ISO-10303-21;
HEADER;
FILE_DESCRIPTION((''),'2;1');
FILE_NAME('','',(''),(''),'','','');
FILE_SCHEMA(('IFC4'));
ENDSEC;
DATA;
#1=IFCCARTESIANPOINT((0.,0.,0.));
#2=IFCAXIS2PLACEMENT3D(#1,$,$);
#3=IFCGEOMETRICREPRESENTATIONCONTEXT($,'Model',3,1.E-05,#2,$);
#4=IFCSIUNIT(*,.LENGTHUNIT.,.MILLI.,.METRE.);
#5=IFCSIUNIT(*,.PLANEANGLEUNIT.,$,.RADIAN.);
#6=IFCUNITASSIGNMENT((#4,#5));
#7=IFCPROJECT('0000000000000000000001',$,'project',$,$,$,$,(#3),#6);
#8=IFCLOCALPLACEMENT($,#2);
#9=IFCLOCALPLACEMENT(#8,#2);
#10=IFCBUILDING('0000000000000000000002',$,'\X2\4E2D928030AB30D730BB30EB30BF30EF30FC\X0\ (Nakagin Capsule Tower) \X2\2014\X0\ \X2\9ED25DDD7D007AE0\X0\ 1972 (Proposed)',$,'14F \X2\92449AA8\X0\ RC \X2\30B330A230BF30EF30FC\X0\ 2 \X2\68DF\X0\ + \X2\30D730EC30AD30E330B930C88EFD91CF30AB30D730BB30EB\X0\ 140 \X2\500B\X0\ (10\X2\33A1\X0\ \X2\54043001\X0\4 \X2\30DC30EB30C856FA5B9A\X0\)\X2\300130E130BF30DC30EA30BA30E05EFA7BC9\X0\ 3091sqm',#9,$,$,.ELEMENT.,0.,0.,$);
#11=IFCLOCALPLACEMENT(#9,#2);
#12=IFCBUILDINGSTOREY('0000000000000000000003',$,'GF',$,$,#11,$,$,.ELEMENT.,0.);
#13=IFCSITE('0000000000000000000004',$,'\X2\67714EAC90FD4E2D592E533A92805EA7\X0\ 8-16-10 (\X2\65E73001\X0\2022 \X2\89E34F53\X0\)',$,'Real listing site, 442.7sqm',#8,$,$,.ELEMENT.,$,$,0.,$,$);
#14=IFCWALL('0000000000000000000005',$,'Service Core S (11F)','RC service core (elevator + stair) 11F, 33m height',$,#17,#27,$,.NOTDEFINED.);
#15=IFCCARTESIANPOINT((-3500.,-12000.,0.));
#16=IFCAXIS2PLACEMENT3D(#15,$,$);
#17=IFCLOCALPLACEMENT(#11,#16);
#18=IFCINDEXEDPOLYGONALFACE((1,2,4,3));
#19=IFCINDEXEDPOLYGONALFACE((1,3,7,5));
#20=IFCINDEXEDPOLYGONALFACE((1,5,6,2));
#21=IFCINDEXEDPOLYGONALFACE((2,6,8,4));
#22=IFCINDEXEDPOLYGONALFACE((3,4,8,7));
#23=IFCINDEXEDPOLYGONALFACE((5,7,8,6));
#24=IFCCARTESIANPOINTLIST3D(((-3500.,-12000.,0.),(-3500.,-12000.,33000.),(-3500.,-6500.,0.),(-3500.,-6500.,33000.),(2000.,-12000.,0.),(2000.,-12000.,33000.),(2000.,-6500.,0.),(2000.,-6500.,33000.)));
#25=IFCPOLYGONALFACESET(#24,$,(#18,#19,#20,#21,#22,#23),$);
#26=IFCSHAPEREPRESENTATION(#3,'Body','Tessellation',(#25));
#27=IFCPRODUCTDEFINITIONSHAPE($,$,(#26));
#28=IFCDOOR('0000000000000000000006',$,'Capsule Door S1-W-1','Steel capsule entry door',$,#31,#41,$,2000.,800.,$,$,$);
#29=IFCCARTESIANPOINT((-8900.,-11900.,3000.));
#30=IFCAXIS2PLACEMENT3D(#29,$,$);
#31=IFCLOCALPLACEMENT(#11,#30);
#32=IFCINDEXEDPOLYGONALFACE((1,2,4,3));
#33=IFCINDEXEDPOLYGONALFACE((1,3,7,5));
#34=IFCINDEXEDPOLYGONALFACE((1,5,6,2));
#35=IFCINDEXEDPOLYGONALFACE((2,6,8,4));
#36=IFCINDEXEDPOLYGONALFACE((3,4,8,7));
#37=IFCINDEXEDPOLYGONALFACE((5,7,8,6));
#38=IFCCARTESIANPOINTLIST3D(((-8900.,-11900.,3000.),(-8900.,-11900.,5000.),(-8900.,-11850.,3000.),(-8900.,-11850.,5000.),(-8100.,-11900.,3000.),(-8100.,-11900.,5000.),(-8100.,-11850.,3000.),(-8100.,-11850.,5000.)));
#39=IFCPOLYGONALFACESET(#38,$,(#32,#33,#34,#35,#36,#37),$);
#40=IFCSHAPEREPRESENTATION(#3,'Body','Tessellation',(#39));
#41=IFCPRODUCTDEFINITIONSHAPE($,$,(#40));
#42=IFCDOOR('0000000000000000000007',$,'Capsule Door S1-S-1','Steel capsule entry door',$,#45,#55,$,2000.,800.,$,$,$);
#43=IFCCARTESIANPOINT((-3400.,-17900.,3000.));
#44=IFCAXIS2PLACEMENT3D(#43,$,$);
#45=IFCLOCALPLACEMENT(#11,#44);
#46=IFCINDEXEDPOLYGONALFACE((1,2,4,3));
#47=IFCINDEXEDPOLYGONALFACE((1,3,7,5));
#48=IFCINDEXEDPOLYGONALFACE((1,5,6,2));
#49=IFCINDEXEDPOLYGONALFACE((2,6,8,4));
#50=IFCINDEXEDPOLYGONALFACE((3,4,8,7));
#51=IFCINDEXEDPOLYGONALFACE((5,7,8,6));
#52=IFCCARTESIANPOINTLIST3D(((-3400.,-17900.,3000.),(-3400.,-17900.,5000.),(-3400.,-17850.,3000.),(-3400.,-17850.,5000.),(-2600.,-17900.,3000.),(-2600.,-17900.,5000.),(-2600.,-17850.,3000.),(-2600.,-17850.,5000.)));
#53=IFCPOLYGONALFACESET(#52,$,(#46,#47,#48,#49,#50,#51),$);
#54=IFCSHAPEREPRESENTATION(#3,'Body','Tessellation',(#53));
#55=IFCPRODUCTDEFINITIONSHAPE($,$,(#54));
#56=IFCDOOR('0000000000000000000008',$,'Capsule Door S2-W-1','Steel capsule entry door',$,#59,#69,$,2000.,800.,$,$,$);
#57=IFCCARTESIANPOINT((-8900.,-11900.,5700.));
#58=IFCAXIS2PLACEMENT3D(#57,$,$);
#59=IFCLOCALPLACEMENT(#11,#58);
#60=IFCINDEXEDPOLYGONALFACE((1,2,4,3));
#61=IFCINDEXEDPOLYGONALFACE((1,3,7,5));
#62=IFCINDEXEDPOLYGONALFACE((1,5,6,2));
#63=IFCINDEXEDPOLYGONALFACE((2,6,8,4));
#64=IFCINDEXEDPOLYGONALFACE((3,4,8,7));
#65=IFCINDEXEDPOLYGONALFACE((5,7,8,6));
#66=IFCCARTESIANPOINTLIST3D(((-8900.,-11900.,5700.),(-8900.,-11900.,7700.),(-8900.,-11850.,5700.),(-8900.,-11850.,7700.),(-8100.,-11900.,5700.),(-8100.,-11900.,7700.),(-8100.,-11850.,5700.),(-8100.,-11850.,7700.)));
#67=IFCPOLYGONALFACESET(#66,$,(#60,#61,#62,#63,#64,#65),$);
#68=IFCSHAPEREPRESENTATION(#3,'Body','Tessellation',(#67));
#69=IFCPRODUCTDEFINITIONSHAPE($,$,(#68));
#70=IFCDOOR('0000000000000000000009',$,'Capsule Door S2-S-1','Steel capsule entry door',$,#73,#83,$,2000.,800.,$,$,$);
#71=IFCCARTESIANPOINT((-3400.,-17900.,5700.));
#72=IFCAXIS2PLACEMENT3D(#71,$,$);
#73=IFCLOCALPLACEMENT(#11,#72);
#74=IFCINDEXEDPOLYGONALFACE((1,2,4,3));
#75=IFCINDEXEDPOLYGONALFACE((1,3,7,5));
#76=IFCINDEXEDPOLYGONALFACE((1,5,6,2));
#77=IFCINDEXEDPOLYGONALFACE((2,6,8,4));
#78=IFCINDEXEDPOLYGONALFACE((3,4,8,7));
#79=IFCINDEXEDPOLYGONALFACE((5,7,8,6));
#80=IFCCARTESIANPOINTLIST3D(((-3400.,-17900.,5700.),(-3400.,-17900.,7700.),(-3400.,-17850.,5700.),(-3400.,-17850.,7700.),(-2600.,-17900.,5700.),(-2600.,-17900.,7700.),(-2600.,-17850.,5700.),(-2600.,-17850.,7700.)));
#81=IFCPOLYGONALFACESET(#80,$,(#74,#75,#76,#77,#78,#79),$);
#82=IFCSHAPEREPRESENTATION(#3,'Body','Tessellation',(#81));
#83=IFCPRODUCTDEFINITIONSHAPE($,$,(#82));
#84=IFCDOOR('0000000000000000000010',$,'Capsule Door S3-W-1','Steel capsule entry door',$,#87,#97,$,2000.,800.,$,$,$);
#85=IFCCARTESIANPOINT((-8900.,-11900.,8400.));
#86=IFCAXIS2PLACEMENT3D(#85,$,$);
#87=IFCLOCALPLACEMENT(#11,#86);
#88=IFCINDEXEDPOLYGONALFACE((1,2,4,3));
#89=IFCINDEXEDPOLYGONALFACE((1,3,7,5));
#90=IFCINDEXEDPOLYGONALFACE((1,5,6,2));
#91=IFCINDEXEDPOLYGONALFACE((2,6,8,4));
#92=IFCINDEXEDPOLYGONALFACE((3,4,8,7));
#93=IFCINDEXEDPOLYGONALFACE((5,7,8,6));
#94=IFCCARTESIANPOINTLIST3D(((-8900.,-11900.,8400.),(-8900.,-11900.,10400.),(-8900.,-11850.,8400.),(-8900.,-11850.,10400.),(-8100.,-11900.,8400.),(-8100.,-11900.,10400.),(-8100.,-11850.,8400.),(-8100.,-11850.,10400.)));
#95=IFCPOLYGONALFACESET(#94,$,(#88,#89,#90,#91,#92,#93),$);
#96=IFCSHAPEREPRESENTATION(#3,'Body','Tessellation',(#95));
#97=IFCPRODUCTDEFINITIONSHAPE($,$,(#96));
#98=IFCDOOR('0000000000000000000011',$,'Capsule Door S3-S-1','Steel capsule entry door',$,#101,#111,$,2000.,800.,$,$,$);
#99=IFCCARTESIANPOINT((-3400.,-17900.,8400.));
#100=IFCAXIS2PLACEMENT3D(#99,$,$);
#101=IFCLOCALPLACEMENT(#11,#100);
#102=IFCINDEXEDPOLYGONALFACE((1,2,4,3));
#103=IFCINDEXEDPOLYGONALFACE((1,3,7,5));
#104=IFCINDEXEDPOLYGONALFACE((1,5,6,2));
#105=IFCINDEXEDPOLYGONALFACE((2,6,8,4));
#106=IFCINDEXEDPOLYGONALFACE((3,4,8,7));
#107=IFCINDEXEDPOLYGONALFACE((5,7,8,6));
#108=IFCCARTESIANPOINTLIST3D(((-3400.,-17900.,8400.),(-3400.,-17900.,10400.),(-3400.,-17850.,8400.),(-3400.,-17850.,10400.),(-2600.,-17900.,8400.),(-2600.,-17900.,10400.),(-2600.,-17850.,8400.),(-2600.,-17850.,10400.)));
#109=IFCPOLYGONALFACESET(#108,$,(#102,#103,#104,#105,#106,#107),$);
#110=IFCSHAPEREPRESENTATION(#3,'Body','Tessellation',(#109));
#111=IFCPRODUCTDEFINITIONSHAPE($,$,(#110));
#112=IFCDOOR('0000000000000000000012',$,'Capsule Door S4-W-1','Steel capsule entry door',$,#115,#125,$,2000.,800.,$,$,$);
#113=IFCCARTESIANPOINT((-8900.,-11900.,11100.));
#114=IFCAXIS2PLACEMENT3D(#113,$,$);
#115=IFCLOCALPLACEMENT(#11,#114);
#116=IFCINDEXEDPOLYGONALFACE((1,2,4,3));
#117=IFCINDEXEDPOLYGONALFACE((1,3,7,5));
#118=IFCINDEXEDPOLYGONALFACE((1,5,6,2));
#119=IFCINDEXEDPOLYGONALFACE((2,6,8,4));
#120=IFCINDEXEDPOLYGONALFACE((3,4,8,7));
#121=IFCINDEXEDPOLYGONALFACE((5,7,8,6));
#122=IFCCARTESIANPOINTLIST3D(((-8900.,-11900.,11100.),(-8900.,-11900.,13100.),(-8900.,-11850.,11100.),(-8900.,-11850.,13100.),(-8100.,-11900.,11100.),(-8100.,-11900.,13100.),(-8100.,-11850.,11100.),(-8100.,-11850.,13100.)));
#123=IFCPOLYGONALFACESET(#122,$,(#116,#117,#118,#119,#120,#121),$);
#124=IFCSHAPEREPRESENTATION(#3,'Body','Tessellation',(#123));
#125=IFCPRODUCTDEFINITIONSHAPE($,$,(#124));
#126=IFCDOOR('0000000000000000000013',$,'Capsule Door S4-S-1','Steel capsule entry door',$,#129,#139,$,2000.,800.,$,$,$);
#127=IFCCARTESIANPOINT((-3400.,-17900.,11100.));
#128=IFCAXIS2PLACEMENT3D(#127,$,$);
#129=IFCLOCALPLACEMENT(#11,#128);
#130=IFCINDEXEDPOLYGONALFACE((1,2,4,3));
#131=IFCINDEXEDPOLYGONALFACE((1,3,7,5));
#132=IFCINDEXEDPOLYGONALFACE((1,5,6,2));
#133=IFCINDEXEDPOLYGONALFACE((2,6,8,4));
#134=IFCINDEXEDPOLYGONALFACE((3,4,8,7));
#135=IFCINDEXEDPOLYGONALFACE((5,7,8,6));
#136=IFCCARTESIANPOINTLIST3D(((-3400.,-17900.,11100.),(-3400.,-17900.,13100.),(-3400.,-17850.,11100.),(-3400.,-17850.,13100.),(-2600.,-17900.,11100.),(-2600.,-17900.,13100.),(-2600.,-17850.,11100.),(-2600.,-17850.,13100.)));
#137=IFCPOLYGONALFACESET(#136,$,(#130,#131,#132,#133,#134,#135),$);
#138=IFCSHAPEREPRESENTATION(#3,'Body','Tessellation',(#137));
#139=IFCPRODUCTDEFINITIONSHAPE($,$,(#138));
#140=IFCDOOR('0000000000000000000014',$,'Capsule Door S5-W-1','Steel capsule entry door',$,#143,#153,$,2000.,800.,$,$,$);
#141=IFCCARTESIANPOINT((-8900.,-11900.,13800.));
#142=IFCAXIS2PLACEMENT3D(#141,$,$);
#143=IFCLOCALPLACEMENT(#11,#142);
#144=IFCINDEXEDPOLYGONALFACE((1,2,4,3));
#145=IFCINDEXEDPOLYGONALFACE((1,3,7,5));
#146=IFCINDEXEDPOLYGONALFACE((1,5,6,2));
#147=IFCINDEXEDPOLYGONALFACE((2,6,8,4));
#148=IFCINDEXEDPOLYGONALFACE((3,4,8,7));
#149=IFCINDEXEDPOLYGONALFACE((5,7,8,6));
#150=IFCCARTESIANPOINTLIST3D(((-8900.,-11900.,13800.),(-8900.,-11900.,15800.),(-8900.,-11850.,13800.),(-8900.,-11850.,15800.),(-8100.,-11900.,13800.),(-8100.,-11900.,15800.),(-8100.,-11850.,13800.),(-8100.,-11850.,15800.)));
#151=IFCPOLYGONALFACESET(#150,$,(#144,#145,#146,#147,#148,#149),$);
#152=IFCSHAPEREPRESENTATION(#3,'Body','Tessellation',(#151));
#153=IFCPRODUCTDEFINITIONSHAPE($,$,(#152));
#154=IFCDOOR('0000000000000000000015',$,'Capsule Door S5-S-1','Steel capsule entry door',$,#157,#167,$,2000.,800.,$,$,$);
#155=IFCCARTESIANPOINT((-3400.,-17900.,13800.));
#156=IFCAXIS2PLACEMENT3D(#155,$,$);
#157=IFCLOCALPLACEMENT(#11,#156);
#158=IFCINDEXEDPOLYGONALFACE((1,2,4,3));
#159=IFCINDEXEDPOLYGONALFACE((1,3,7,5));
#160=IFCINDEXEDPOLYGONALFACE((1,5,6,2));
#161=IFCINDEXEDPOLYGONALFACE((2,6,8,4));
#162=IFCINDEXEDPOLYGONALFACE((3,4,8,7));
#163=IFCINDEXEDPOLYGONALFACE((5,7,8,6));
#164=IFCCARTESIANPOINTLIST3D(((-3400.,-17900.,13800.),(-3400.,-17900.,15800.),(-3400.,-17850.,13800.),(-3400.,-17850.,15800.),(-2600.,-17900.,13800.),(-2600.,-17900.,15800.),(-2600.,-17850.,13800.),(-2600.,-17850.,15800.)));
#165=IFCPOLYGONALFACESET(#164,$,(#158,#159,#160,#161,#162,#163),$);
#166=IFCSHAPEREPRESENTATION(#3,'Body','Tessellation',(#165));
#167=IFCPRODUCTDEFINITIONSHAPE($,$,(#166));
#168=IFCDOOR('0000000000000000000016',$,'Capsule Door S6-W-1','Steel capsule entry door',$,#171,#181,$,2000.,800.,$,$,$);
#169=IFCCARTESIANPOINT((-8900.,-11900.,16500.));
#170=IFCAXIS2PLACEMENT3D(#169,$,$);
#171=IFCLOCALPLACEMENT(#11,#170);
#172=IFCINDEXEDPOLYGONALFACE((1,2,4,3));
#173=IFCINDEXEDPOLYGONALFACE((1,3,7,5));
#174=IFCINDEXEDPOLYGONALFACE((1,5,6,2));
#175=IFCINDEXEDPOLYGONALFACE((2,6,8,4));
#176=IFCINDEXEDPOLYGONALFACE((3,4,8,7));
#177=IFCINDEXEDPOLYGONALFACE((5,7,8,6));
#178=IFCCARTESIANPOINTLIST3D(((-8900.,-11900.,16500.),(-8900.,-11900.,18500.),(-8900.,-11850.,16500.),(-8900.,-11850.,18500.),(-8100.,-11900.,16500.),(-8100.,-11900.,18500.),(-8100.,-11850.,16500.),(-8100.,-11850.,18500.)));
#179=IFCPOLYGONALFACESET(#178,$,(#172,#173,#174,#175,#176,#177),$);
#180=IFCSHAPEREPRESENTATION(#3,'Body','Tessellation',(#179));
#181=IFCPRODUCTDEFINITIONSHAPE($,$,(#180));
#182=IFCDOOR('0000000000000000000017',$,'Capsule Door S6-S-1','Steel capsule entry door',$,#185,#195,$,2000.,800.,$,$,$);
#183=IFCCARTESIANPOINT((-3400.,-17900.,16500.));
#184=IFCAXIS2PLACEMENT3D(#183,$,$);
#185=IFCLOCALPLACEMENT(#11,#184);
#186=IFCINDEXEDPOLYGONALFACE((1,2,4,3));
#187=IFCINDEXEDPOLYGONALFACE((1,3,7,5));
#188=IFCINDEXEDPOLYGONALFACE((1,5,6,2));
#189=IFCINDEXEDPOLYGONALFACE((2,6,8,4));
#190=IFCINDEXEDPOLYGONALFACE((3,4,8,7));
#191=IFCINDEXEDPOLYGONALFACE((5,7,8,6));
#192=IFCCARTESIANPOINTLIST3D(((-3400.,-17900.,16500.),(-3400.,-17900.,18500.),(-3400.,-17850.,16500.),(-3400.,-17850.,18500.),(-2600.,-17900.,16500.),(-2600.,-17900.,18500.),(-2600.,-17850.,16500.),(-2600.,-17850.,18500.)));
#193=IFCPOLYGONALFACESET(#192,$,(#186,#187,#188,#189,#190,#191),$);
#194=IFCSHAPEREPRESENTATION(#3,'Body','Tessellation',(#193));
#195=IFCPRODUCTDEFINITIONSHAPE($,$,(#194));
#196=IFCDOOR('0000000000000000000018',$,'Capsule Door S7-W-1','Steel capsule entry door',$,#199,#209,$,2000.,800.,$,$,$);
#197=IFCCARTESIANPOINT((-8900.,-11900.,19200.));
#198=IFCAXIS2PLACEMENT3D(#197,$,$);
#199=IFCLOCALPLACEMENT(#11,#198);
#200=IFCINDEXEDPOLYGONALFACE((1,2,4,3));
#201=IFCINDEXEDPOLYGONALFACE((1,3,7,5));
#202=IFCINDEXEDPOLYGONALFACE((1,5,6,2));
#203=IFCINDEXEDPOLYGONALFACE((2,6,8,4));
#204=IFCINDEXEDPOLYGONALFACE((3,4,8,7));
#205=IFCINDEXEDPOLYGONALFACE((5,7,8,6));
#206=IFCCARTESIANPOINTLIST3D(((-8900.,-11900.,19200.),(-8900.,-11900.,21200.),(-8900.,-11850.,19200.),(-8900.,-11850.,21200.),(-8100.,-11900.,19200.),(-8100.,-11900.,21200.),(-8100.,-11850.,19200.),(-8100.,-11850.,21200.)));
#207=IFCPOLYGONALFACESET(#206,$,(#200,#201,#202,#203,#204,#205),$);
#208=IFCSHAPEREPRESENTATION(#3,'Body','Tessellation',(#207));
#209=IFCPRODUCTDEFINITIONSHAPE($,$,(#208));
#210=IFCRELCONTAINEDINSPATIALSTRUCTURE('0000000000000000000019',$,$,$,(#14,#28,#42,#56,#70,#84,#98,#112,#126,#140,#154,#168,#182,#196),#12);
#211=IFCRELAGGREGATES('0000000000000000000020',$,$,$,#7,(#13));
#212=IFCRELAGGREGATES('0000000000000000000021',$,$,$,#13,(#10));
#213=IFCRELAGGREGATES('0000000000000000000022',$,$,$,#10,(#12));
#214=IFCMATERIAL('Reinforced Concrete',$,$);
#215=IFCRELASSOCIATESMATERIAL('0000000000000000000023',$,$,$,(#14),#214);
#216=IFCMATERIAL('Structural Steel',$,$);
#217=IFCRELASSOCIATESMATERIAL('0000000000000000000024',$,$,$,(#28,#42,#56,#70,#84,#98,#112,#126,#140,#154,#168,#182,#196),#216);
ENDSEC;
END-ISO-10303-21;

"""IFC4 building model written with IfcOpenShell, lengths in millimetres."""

from ifc_helpers import new_model, si_unit, frame, frame_2d, origin, place, context, project, spatial, rectangle, extrude, material, element, save


model = new_model("IFC4")

# Units and contexts
model_context = context("Model", 3, precision=1e-05, world=origin())
ifc_project = project(units=[si_unit("LENGTHUNIT", "METRE", prefix="MILLI"), si_unit("PLANEANGLEUNIT", "RADIAN")], contexts=[model_context])

# Site, building, storey
site_placement = place(None, origin())
site = spatial("IfcSite", under=ifc_project, at=site_placement, Name="東京都中央区銀座 8-16-10 (旧、2022 解体)", ObjectType="Real listing site, 442.7sqm", CompositionType="ELEMENT", RefElevation=0.0)
building_placement = place(site_placement, origin())
building = spatial("IfcBuilding", under=site, at=building_placement, Name="中銀カプセルタワー (Nakagin Capsule Tower) — 黒川紀章 1972 (Proposed)", ObjectType="14F 鉄骨 RC コアタワー 2 棟 + プレキャスト軽量カプセル 140 個 (10㎡ 各、4 ボルト固定)、メタボリズム建築 3091sqm", CompositionType="ELEMENT", ElevationOfRefHeight=0.0, ElevationOfTerrain=0.0)
storey_placement = place(building_placement, origin())
storey = spatial("IfcBuildingStorey", under=building, at=storey_placement, Name="GF", CompositionType="ELEMENT", Elevation=0.0)

# Shared definitions
ifc_material_1 = material(Name="Reinforced Concrete")

# Wall
wall_placement = place(storey_placement, frame((-3500.0, -12000.0, 0.0)))
element("IfcWall", 1, at=wall_placement, inside=storey, material=ifc_material_1, Name="Service Core S (11F)", Description="RC service core (elevator + stair) 11F, 33m height", PredefinedType="NOTDEFINED", context=model_context, shape_type="SweptSolid", body=[
    extrude(rectangle(XDim=5500.0, YDim=5500.0, at=frame_2d((2750.0, 2750.0))), frame((-3500.0, -12000.0, 0.0)), (0.0, 0.0, 1.0), 33000.0),
])

# Doors
ifc_material_2 = material(Name="Structural Steel")
door_1_placement = place(storey_placement, frame((-8900.0, -11900.0, 3000.0)))
element("IfcDoor", 2, at=door_1_placement, inside=storey, material=ifc_material_2, Name="Capsule Door S1-W-1", Description="Steel capsule entry door", OverallHeight=2000.0, OverallWidth=800.0, context=model_context, shape_type="SweptSolid", body=[
    extrude(rectangle(XDim=800.0, YDim=50.0, at=frame_2d((400.0, 25.0))), frame((-8900.0, -11900.0, 3000.0)), (0.0, 0.0, 1.0), 2000.0),
])
door_2_placement = place(storey_placement, frame((-3400.0, -17900.0, 3000.0)))
element("IfcDoor", 3, at=door_2_placement, inside=storey, material=ifc_material_2, Name="Capsule Door S1-S-1", Description="Steel capsule entry door", OverallHeight=2000.0, OverallWidth=800.0, context=model_context, shape_type="SweptSolid", body=[
    extrude(rectangle(XDim=800.0, YDim=50.0, at=frame_2d((400.0, 25.0))), frame((-3400.0, -17900.0, 3000.0)), (0.0, 0.0, 1.0), 2000.0),
])
door_3_placement = place(storey_placement, frame((-8900.0, -11900.0, 5700.0)))
element("IfcDoor", 4, at=door_3_placement, inside=storey, material=ifc_material_2, Name="Capsule Door S2-W-1", Description="Steel capsule entry door", OverallHeight=2000.0, OverallWidth=800.0, context=model_context, shape_type="SweptSolid", body=[
    extrude(rectangle(XDim=800.0, YDim=50.0, at=frame_2d((400.0, 25.0))), frame((-8900.0, -11900.0, 5700.0)), (0.0, 0.0, 1.0), 2000.0),
])
door_4_placement = place(storey_placement, frame((-3400.0, -17900.0, 5700.0)))
element("IfcDoor", 5, at=door_4_placement, inside=storey, material=ifc_material_2, Name="Capsule Door S2-S-1", Description="Steel capsule entry door", OverallHeight=2000.0, OverallWidth=800.0, context=model_context, shape_type="SweptSolid", body=[
    extrude(rectangle(XDim=800.0, YDim=50.0, at=frame_2d((400.0, 25.0))), frame((-3400.0, -17900.0, 5700.0)), (0.0, 0.0, 1.0), 2000.0),
])
door_5_placement = place(storey_placement, frame((-8900.0, -11900.0, 8400.0)))
element("IfcDoor", 6, at=door_5_placement, inside=storey, material=ifc_material_2, Name="Capsule Door S3-W-1", Description="Steel capsule entry door", OverallHeight=2000.0, OverallWidth=800.0, context=model_context, shape_type="SweptSolid", body=[
    extrude(rectangle(XDim=800.0, YDim=50.0, at=frame_2d((400.0, 25.0))), frame((-8900.0, -11900.0, 8400.0)), (0.0, 0.0, 1.0), 2000.0),
])
door_6_placement = place(storey_placement, frame((-3400.0, -17900.0, 8400.0)))
element("IfcDoor", 7, at=door_6_placement, inside=storey, material=ifc_material_2, Name="Capsule Door S3-S-1", Description="Steel capsule entry door", OverallHeight=2000.0, OverallWidth=800.0, context=model_context, shape_type="SweptSolid", body=[
    extrude(rectangle(XDim=800.0, YDim=50.0, at=frame_2d((400.0, 25.0))), frame((-3400.0, -17900.0, 8400.0)), (0.0, 0.0, 1.0), 2000.0),
])
door_7_placement = place(storey_placement, frame((-8900.0, -11900.0, 11100.0)))
element("IfcDoor", 8, at=door_7_placement, inside=storey, material=ifc_material_2, Name="Capsule Door S4-W-1", Description="Steel capsule entry door", OverallHeight=2000.0, OverallWidth=800.0, context=model_context, shape_type="SweptSolid", body=[
    extrude(rectangle(XDim=800.0, YDim=50.0, at=frame_2d((400.0, 25.0))), frame((-8900.0, -11900.0, 11100.0)), (0.0, 0.0, 1.0), 2000.0),
])
door_8_placement = place(storey_placement, frame((-3400.0, -17900.0, 11100.0)))
element("IfcDoor", 9, at=door_8_placement, inside=storey, material=ifc_material_2, Name="Capsule Door S4-S-1", Description="Steel capsule entry door", OverallHeight=2000.0, OverallWidth=800.0, context=model_context, shape_type="SweptSolid", body=[
    extrude(rectangle(XDim=800.0, YDim=50.0, at=frame_2d((400.0, 25.0))), frame((-3400.0, -17900.0, 11100.0)), (0.0, 0.0, 1.0), 2000.0),
])
door_9_placement = place(storey_placement, frame((-8900.0, -11900.0, 13800.0)))
element("IfcDoor", 10, at=door_9_placement, inside=storey, material=ifc_material_2, Name="Capsule Door S5-W-1", Description="Steel capsule entry door", OverallHeight=2000.0, OverallWidth=800.0, context=model_context, shape_type="SweptSolid", body=[
    extrude(rectangle(XDim=800.0, YDim=50.0, at=frame_2d((400.0, 25.0))), frame((-8900.0, -11900.0, 13800.0)), (0.0, 0.0, 1.0), 2000.0),
])
door_10_placement = place(storey_placement, frame((-3400.0, -17900.0, 13800.0)))
element("IfcDoor", 11, at=door_10_placement, inside=storey, material=ifc_material_2, Name="Capsule Door S5-S-1", Description="Steel capsule entry door", OverallHeight=2000.0, OverallWidth=800.0, context=model_context, shape_type="SweptSolid", body=[
    extrude(rectangle(XDim=800.0, YDim=50.0, at=frame_2d((400.0, 25.0))), frame((-3400.0, -17900.0, 13800.0)), (0.0, 0.0, 1.0), 2000.0),
])
door_11_placement = place(storey_placement, frame((-8900.0, -11900.0, 16500.0)))
element("IfcDoor", 12, at=door_11_placement, inside=storey, material=ifc_material_2, Name="Capsule Door S6-W-1", Description="Steel capsule entry door", OverallHeight=2000.0, OverallWidth=800.0, context=model_context, shape_type="SweptSolid", body=[
    extrude(rectangle(XDim=800.0, YDim=50.0, at=frame_2d((400.0, 25.0))), frame((-8900.0, -11900.0, 16500.0)), (0.0, 0.0, 1.0), 2000.0),
])
door_12_placement = place(storey_placement, frame((-3400.0, -17900.0, 16500.0)))
element("IfcDoor", 13, at=door_12_placement, inside=storey, material=ifc_material_2, Name="Capsule Door S6-S-1", Description="Steel capsule entry door", OverallHeight=2000.0, OverallWidth=800.0, context=model_context, shape_type="SweptSolid", body=[
    extrude(rectangle(XDim=800.0, YDim=50.0, at=frame_2d((400.0, 25.0))), frame((-3400.0, -17900.0, 16500.0)), (0.0, 0.0, 1.0), 2000.0),
])
door_13_placement = place(storey_placement, frame((-8900.0, -11900.0, 19200.0)))
element("IfcDoor", 14, at=door_13_placement, inside=storey, material=ifc_material_2, Name="Capsule Door S7-W-1", Description="Steel capsule entry door", OverallHeight=2000.0, OverallWidth=800.0, context=model_context, shape_type="SweptSolid", body=[
    extrude(rectangle(XDim=800.0, YDim=50.0, at=frame_2d((400.0, 25.0))), frame((-8900.0, -11900.0, 19200.0)), (0.0, 0.0, 1.0), 2000.0),
])

save(model, "model.ifc")
